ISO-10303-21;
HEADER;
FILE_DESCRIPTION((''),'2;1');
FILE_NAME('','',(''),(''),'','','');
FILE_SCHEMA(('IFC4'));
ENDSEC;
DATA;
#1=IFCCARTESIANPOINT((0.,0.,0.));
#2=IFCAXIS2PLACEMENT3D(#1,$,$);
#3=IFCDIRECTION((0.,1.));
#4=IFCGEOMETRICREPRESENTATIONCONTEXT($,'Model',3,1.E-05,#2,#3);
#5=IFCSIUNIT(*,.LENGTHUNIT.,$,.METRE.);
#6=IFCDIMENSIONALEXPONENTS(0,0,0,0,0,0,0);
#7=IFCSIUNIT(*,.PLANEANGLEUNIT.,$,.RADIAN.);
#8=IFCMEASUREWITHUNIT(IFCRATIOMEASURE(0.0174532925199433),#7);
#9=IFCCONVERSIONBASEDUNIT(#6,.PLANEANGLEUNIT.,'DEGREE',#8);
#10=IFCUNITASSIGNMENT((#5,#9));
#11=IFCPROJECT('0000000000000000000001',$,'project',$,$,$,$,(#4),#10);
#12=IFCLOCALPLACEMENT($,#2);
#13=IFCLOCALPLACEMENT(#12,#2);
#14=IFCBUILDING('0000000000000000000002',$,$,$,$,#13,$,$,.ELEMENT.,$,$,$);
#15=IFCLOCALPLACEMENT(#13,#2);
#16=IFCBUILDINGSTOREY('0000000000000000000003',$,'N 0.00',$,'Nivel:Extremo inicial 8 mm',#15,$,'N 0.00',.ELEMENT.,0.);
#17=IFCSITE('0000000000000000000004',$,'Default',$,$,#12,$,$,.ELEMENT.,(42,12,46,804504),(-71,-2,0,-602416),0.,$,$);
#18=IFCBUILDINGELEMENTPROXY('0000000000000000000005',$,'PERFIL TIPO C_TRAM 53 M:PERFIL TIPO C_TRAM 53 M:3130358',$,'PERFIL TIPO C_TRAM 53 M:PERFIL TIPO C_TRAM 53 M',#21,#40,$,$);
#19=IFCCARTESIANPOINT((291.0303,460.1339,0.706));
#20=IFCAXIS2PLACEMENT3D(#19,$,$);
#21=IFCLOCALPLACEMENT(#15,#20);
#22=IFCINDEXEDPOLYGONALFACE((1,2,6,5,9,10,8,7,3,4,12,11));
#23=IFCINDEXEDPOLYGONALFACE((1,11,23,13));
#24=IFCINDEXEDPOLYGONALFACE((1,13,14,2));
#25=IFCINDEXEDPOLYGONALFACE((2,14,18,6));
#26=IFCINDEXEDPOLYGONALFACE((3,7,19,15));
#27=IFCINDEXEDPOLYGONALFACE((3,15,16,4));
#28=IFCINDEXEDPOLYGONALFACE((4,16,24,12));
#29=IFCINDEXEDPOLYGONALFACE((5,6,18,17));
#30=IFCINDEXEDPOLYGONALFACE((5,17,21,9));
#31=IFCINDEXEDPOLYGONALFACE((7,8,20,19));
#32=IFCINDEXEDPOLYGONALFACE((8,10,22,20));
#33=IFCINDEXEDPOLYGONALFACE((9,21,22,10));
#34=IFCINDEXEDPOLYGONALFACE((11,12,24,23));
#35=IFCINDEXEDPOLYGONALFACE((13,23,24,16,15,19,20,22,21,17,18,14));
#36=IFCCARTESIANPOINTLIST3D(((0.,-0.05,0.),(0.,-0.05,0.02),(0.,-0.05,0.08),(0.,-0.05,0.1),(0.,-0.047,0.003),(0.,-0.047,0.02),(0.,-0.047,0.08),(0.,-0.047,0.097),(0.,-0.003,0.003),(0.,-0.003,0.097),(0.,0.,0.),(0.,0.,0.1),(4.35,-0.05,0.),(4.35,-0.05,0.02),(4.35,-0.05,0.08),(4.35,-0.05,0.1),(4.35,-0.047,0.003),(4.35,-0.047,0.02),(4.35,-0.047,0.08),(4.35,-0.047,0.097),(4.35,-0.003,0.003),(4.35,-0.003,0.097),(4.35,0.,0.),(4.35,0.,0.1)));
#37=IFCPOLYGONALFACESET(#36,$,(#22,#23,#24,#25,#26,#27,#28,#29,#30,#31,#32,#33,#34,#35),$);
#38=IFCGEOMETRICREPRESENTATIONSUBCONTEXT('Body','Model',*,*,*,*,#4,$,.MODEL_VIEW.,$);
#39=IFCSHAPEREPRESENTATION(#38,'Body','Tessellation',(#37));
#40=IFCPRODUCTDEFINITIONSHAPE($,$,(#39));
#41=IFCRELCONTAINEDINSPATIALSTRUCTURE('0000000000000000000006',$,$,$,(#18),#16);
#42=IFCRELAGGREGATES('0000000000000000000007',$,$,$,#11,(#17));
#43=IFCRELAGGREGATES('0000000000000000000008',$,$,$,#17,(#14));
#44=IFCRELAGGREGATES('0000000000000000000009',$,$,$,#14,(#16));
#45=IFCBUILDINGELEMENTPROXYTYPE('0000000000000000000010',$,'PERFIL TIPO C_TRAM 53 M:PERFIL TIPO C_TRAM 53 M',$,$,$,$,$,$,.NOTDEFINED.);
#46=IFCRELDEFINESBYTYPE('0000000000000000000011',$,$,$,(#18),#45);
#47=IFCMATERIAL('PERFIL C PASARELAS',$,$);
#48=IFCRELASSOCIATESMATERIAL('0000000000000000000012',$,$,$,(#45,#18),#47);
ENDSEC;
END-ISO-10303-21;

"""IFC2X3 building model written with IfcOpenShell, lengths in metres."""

from ifc_helpers import new_model, entity, si_unit, converted_unit, direction, frame, origin, place, context, subcontext, project, spatial, polyline, outline, extrude, source, transform, mapped, material, type_object, type_shapes, element, save


model = new_model("IFC2X3")

# Units and contexts
model_context = context("Model", 3, precision=1e-05, world=origin(), true_north=direction((0.0, 1.0)))
body_context = subcontext(model_context, "Body", "Model", "MODEL_VIEW")
ifc_project = project(units=[si_unit("LENGTHUNIT", "METRE"), converted_unit("PLANEANGLEUNIT", "DEGREE", entity("IfcRatioMeasure", 0.0174532925199433), si_unit("PLANEANGLEUNIT", "RADIAN"), dimensions=[0, 0, 0, 0, 0, 0, 0])], contexts=[model_context])

# Site, building, storey
site_placement = place(None, origin())
site = spatial("IfcSite", under=ifc_project, at=site_placement, Name="Default", CompositionType="ELEMENT", RefLatitude=(42, 12, 46, 804504), RefLongitude=(-71, -2, 0, -602416), RefElevation=0.0)
building_placement = place(site_placement, origin())
building = spatial("IfcBuilding", under=site, at=building_placement, CompositionType="ELEMENT")
storey_placement = place(building_placement, origin())
storey = spatial("IfcBuildingStorey", under=building, at=storey_placement, Name="N 0.00", ObjectType="Nivel:Extremo inicial 8 mm", LongName="N 0.00", CompositionType="ELEMENT", Elevation=0.0)

# Building element proxy
ifc_material_1 = material(Name="PERFIL C PASARELAS")
building_element_proxy_type_1 = type_object("IfcBuildingElementProxyType", Name="PERFIL TIPO C_TRAM 53 M:PERFIL TIPO C_TRAM 53 M", PredefinedType="NOTDEFINED", material=ifc_material_1)
shared_shape_1 = source(origin(), body_context, "Body", "SweptSolid", [
    extrude(outline(polyline([(0.03, -0.0172), (0.05, -0.0172), (0.05, 0.0328), (-0.05, 0.0328), (-0.05, -0.0172), (-0.03, -0.0172), (-0.03, -0.0142), (-0.047, -0.0142), (-0.047, 0.0298), (0.047, 0.0298), (0.047, -0.0142), (0.03, -0.0142), (0.03, -0.0172)])), frame((0.0, -0.0328, 0.05), z_axis=(1.0, 0.0, 0.0), x_axis=(0.0, 0.0, -1.0)), (0.0, 0.0, 1.0), 4.35),
])
type_shapes(building_element_proxy_type_1, [shared_shape_1])
proxy_1_placement = place(storey_placement, frame((291.0303, 460.1339, 0.706)))
element("IfcBuildingElementProxy", 1, at=proxy_1_placement, inside=storey, type_object=building_element_proxy_type_1, material=ifc_material_1, Name="PERFIL TIPO C_TRAM 53 M:PERFIL TIPO C_TRAM 53 M:3130358", ObjectType="PERFIL TIPO C_TRAM 53 M:PERFIL TIPO C_TRAM 53 M", context=body_context, shape_type="MappedRepresentation", body=[
    mapped(shared_shape_1, transform((0.0, 0.0, 0.0), scale=1.0)),
])

save(model, "model.ifc")
